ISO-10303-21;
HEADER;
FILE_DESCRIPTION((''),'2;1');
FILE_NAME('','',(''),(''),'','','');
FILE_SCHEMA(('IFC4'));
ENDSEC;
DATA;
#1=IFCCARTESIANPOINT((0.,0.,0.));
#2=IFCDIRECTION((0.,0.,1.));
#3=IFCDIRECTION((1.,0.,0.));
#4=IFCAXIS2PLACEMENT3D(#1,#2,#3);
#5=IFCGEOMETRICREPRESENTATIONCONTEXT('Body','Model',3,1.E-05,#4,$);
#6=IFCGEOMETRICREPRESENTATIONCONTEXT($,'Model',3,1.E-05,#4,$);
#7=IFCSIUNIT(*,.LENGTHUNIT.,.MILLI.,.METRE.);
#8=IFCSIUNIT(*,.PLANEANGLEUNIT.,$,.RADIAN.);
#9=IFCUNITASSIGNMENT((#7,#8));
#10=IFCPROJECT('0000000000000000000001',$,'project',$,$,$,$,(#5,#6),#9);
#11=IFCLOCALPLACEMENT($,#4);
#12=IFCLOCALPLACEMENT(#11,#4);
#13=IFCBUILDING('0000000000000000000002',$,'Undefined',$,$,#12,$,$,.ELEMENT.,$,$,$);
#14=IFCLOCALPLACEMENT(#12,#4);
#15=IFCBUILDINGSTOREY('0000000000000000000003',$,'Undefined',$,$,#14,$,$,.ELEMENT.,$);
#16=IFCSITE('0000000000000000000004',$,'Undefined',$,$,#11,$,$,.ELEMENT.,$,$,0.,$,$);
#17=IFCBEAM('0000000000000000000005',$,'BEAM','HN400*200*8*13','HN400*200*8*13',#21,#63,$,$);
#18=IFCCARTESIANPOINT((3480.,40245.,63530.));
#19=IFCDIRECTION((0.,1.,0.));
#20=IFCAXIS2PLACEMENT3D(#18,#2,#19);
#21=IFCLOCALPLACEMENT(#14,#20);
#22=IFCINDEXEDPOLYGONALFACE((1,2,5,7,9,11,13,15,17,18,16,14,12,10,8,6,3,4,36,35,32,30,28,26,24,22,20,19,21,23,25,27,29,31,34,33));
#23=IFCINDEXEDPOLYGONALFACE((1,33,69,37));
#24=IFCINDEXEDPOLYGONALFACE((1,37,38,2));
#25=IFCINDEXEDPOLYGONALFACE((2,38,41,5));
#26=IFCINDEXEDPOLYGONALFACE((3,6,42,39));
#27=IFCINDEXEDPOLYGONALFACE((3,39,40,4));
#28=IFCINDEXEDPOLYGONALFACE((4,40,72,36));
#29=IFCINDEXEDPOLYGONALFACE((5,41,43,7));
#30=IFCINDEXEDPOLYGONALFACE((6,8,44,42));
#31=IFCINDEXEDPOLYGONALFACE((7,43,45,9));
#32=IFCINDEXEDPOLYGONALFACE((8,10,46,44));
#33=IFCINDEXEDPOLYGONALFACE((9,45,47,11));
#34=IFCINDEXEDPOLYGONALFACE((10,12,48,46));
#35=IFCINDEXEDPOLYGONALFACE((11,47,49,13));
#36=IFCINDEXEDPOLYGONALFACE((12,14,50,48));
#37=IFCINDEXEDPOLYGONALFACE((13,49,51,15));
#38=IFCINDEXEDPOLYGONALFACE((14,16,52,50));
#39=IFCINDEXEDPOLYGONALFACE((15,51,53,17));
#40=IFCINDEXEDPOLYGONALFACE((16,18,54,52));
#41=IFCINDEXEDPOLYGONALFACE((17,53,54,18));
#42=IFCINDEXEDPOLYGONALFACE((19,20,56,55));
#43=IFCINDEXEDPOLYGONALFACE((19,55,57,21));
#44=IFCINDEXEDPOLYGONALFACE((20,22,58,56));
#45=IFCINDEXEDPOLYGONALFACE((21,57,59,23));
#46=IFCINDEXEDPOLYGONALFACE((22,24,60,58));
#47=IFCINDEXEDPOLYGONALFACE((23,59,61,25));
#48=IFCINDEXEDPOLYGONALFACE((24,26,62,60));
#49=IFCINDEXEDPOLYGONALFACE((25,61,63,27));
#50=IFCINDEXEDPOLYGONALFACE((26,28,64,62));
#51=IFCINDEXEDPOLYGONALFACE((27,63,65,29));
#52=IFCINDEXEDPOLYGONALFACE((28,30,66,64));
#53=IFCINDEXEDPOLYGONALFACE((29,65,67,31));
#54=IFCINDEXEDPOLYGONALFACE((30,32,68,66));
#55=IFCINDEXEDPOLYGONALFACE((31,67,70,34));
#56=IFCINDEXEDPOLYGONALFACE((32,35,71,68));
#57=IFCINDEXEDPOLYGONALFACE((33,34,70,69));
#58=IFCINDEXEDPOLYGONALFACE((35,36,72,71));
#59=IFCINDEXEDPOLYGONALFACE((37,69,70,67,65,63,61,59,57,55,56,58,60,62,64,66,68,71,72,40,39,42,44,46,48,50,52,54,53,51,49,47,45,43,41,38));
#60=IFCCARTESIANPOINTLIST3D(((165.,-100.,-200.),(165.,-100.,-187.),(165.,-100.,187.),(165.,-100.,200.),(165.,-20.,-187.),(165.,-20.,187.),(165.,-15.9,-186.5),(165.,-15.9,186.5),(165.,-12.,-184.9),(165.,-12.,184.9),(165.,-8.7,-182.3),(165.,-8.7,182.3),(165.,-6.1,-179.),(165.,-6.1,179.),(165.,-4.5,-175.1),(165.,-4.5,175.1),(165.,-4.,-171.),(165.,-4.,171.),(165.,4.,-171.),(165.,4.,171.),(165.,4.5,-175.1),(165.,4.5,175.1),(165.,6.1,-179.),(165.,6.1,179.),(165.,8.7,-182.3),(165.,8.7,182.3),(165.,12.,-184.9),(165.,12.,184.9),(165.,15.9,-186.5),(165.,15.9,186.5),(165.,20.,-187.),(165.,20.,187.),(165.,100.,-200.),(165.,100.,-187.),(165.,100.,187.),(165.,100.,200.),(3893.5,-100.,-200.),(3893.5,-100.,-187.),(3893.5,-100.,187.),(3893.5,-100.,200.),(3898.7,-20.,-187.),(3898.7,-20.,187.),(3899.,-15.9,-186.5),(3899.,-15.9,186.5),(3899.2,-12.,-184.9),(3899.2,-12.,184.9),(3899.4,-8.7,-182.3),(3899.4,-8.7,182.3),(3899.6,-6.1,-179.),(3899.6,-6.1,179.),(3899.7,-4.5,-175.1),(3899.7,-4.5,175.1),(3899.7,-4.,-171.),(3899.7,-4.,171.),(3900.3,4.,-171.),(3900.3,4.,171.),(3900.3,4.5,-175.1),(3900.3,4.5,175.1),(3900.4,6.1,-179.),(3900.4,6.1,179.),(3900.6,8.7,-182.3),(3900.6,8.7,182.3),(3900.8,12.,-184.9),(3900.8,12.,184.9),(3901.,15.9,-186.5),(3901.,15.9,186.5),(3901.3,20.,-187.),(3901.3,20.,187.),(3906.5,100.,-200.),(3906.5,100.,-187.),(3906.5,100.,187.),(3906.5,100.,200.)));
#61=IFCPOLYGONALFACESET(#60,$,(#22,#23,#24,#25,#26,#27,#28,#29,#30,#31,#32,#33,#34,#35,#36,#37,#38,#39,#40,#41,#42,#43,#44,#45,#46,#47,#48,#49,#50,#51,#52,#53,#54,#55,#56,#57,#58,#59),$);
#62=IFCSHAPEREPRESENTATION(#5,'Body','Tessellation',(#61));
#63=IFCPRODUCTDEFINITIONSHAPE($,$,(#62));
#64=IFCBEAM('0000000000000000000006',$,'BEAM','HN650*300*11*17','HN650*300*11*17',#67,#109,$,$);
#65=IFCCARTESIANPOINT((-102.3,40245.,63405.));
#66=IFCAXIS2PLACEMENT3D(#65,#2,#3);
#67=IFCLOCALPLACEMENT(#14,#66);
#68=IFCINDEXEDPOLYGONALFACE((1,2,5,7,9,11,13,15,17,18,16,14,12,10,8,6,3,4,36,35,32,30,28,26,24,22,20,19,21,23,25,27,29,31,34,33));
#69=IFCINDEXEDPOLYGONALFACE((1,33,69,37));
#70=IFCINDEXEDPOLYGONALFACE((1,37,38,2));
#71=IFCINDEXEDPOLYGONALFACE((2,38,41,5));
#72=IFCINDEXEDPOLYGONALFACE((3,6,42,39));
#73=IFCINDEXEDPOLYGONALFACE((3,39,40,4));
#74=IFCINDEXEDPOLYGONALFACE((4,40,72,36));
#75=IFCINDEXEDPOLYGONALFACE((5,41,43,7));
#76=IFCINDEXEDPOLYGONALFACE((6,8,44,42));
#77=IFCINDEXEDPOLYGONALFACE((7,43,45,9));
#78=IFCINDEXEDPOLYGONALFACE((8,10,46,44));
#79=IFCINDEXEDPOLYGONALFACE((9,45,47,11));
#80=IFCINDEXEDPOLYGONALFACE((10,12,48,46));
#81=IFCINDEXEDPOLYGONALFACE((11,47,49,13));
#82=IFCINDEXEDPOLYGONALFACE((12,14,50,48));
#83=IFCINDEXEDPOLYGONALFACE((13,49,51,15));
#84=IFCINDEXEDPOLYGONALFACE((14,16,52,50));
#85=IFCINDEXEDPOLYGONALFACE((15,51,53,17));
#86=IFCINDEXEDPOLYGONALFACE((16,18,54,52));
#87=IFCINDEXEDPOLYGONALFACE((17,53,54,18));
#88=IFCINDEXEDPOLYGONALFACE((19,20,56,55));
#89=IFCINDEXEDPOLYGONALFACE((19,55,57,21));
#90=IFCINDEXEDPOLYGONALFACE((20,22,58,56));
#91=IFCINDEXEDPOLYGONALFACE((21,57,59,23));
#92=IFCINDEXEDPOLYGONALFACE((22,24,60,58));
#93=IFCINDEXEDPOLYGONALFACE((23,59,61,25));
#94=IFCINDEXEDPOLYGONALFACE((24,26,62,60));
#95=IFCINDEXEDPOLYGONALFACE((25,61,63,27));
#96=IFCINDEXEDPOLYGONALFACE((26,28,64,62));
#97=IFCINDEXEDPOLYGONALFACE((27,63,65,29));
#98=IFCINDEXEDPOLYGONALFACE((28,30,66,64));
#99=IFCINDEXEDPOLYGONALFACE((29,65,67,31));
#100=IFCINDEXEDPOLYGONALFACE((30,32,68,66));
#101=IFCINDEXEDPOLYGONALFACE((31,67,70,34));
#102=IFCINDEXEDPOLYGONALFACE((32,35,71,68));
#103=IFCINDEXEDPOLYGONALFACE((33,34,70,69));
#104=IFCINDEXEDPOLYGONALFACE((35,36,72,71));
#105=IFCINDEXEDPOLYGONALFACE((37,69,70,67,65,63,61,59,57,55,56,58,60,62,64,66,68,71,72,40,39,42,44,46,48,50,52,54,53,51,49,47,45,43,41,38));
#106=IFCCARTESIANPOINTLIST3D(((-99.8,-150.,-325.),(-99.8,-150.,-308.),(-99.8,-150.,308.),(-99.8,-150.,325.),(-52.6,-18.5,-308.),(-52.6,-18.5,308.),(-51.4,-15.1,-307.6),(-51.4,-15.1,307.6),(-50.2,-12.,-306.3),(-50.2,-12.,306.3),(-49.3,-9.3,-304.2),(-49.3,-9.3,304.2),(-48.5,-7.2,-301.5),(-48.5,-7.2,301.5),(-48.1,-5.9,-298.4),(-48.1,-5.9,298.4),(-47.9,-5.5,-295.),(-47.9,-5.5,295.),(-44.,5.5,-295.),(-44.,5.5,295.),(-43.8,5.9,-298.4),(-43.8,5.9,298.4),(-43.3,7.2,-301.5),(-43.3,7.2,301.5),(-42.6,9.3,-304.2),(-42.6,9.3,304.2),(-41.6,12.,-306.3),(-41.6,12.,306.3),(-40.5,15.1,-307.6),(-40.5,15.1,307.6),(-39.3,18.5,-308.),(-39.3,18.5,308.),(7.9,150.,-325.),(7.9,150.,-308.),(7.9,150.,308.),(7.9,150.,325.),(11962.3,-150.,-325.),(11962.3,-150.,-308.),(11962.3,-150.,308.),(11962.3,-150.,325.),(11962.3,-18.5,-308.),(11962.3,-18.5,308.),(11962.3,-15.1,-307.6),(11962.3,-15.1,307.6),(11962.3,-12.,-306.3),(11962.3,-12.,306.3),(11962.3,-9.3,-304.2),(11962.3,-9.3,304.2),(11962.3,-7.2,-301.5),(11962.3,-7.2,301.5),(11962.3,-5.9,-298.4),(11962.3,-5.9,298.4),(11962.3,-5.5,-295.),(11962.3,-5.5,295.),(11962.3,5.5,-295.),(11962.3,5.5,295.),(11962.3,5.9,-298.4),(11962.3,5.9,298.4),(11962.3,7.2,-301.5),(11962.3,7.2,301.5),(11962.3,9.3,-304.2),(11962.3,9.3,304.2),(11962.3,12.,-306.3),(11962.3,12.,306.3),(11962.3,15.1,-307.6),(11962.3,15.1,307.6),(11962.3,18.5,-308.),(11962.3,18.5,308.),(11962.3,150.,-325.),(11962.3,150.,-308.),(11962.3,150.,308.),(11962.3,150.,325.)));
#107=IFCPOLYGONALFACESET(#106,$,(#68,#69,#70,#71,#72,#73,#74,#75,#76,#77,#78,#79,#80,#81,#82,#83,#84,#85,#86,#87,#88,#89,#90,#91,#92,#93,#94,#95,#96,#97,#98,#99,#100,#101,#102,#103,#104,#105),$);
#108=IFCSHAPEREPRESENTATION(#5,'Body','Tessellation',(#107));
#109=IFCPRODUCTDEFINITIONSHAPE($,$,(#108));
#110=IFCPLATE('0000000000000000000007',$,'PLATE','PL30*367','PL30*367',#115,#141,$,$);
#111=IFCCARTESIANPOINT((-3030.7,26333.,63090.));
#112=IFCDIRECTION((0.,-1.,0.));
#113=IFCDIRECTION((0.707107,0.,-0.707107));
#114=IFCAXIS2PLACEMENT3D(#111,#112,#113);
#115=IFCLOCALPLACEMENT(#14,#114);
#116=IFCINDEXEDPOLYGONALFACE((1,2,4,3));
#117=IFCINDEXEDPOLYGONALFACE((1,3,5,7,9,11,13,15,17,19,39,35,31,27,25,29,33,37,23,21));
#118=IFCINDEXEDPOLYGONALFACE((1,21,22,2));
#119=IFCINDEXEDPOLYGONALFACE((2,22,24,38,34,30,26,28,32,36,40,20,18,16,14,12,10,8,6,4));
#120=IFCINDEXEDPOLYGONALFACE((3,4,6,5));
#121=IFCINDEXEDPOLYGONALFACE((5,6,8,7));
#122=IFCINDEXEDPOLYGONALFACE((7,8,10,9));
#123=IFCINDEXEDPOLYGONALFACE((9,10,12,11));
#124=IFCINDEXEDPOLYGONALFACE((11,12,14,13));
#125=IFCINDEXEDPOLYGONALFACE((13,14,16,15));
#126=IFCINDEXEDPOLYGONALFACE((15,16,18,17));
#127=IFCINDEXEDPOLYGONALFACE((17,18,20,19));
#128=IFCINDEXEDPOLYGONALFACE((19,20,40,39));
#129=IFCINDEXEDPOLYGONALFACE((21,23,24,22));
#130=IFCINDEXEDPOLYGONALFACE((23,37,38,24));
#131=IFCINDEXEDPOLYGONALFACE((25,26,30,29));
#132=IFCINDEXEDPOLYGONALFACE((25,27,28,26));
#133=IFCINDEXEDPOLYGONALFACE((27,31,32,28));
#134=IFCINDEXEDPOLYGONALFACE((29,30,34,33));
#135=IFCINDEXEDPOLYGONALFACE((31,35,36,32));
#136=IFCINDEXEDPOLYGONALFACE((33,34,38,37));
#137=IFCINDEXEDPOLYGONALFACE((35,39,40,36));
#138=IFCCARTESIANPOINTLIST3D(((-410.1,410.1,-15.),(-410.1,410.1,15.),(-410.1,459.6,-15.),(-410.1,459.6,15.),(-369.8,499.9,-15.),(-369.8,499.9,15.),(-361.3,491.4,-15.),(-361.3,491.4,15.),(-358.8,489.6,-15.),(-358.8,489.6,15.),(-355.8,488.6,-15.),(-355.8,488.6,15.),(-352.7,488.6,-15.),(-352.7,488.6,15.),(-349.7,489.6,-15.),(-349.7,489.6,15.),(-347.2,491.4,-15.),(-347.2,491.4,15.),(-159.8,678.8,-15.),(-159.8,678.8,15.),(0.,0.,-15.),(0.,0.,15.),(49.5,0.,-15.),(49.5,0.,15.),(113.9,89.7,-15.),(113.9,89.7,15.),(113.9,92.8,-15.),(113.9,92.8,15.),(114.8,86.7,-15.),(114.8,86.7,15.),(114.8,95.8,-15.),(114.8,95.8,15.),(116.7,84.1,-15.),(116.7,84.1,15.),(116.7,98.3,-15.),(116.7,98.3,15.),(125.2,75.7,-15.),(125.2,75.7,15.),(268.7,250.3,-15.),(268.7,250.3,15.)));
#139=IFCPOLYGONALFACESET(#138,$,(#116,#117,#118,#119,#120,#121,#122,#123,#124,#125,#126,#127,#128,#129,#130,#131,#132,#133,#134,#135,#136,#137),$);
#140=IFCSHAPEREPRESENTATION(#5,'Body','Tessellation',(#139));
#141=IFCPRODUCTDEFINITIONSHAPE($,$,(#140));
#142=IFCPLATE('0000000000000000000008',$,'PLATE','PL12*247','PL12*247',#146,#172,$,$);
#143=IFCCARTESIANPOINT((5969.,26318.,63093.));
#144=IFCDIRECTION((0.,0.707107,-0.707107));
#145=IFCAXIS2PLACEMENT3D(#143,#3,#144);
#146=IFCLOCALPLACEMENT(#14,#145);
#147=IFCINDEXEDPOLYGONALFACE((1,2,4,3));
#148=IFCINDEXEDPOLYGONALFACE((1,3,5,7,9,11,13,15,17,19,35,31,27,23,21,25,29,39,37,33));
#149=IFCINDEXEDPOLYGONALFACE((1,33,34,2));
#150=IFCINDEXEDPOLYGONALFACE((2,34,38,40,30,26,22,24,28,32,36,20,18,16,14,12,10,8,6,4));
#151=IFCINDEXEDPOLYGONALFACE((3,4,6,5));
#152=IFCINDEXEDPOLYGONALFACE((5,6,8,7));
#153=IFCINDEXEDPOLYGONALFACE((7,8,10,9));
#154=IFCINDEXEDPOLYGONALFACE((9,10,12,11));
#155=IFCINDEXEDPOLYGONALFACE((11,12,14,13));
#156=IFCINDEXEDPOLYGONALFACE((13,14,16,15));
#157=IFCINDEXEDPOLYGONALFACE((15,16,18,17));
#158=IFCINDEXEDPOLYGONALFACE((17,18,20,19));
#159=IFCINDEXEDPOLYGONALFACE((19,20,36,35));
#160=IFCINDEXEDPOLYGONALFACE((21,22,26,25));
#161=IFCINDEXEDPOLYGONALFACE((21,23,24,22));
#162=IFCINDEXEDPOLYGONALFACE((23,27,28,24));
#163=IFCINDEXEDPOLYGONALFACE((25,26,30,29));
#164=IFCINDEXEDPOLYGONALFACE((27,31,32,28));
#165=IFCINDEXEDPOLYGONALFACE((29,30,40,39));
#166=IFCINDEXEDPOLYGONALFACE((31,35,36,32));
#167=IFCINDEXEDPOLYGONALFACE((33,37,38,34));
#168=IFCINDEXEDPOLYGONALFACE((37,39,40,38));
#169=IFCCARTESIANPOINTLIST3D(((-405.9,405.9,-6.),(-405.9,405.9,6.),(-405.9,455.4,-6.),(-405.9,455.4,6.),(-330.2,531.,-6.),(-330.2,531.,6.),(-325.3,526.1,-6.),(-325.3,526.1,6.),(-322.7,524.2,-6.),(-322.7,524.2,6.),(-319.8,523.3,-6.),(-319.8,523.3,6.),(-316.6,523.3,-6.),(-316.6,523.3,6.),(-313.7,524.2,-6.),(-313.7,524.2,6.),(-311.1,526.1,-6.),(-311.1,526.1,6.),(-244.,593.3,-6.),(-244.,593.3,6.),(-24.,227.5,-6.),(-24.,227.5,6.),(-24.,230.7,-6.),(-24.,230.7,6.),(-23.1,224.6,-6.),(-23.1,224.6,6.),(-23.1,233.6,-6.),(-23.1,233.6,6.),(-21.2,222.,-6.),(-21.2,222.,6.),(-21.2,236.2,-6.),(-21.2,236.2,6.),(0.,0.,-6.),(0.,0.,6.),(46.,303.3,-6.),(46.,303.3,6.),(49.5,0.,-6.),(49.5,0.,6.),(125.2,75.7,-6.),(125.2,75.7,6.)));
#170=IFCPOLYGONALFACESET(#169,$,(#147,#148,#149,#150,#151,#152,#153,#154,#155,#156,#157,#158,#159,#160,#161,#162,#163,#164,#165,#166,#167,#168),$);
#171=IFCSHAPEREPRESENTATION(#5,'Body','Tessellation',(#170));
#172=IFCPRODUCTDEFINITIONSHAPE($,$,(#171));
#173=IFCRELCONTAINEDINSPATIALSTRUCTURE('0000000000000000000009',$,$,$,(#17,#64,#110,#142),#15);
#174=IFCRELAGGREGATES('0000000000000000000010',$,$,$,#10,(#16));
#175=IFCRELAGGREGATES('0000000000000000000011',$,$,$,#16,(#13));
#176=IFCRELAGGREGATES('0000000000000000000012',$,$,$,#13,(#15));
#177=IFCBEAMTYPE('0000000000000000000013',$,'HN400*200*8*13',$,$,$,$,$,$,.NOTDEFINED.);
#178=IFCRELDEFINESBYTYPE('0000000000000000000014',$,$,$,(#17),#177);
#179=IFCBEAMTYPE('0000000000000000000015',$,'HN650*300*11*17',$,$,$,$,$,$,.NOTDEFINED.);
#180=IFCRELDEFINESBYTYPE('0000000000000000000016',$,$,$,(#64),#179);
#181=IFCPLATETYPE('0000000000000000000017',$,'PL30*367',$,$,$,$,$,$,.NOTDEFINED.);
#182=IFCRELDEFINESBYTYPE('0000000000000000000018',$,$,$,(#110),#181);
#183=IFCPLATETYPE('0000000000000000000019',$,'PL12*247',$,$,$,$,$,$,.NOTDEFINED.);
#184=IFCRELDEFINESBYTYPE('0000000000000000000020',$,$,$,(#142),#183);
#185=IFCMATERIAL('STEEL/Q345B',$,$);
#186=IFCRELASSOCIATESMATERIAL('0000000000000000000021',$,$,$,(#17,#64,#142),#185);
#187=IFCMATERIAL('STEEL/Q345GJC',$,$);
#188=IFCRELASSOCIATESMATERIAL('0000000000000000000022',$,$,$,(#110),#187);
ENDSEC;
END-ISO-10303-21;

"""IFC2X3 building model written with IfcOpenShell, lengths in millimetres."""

from ifc_helpers import new_model, si_unit, frame, origin_with_axes, origin_2d_with_axis, place, context, project, spatial, polyline, i_section, outline, extrude, clip, halfspace, material, type_object, element, save


model = new_model("IFC2X3")

# Units and contexts
model_context_1 = context("Model", 3, precision=1e-05, world=origin_with_axes(), identifier="Body")
model_context_2 = context("Model", 3, precision=1e-05, world=origin_with_axes())
ifc_project = project(units=[si_unit("LENGTHUNIT", "METRE", prefix="MILLI"), si_unit("PLANEANGLEUNIT", "RADIAN")], contexts=[model_context_1, model_context_2])

# Site, building, storey
site_placement = place(None, origin_with_axes())
site = spatial("IfcSite", under=ifc_project, at=site_placement, Name="Undefined", CompositionType="ELEMENT", RefElevation=0.0)
building_placement = place(site_placement, origin_with_axes())
building = spatial("IfcBuilding", under=site, at=building_placement, Name="Undefined", CompositionType="ELEMENT")
storey_placement = place(building_placement, origin_with_axes())
storey = spatial("IfcBuildingStorey", under=building, at=storey_placement, Name="Undefined", CompositionType="ELEMENT")

# Shared definitions
ifc_material_1 = material(Name="STEEL/Q345B")

# Beams
beam_type_1 = type_object("IfcBeamType", Name="HN400*200*8*13", PredefinedType="NOTDEFINED")
beam_1_placement = place(storey_placement, frame((3480.0, 40245.0, 63530.0), z_axis=(0.0, 0.0, 1.0), x_axis=(0.0, 1.0, 0.0)))
element("IfcBeam", 1, at=beam_1_placement, inside=storey, type_object=beam_type_1, material=ifc_material_1, Name="BEAM", Description="HN400*200*8*13", ObjectType="HN400*200*8*13", context=model_context_1, shape_type="Clipping", body=[
    clip(clip(extrude(i_section(OverallWidth=200.0, OverallDepth=400.0, WebThickness=8.0, FlangeThickness=13.0, FilletRadius=16.0, at=origin_2d_with_axis()), frame((3906.6, 0.0, 0.0), z_axis=(-1.0, 0.0, 0.0), x_axis=(0.0, -1.0, 0.0)), (0.0, 0.0, 1.0), 3741.6), halfspace(frame((3900.9, 13.2, 300.0), z_axis=(0.997873, -0.065183, 0.0), x_axis=(0.065184, 0.997873, 0.0)), False)), halfspace(frame((165.0, 0.0, 300.0), z_axis=(-1.0, 0.0, 0.0), x_axis=(0.0, -1.0, 0.0)), False)),
])
beam_type_2 = type_object("IfcBeamType", Name="HN650*300*11*17", PredefinedType="NOTDEFINED")
beam_2_placement = place(storey_placement, frame((-102.3, 40245.0, 63405.0), z_axis=(0.0, 0.0, 1.0), x_axis=(1.0, 0.0, 0.0)))
element("IfcBeam", 2, at=beam_2_placement, inside=storey, type_object=beam_type_2, material=ifc_material_1, Name="BEAM", Description="HN650*300*11*17", ObjectType="HN650*300*11*17", context=model_context_1, shape_type="Clipping", body=[
    clip(clip(clip(extrude(i_section(OverallWidth=300.0, OverallDepth=650.0, WebThickness=11.0, FlangeThickness=17.0, FilletRadius=13.0, at=origin_2d_with_axis()), frame((11962.3, 0.0, 0.0), z_axis=(-1.0, 0.0, 0.0), x_axis=(0.0, -1.0, 0.0)), (0.0, 0.0, 1.0), 12062.6), halfspace(frame((11962.3, -157.8, 375.0), z_axis=(1.0, 0.0, 0.0), x_axis=(0.0, 0.0, 1.0)), False)), halfspace(frame((-47.7, -5.1, 425.0), z_axis=(-0.941212, 0.337816, 0.0), x_axis=(-0.337816, -0.941212, 0.0)), False)), halfspace(frame((-65.0, -53.0, 425.0), z_axis=(-0.941212, 0.337816, 0.0), x_axis=(-0.337816, -0.941212, 0.0)), False)),
])
ifc_material_2 = material(Name="STEEL/Q345GJC")

# Plates
plate_type_1 = type_object("IfcPlateType", Name="PL30*367", PredefinedType="NOTDEFINED")
plate_1_placement = place(storey_placement, frame((-3030.7, 26333.0, 63090.0), z_axis=(0.0, -1.0, 0.0), x_axis=(0.707107, 0.0, -0.707107)))
element("IfcPlate", 3, at=plate_1_placement, inside=storey, type_object=plate_type_1, material=ifc_material_2, Name="PLATE", Description="PL30*367", ObjectType="PL30*367", context=model_context_1, shape_type="SweptSolid", body=[
    extrude(outline(polyline([(0.0, 0.0), (49.5, 0.0), (125.2, 75.7), (116.7, 84.1), (114.8, 86.7), (113.9, 89.7), (113.9, 92.8), (114.8, 95.8), (116.7, 98.3), (268.7, 250.3), (-159.8, 678.8), (-347.2, 491.4), (-349.7, 489.6), (-352.7, 488.6), (-355.8, 488.6), (-358.8, 489.6), (-361.3, 491.4), (-369.8, 499.9), (-410.1, 459.6), (-410.1, 410.1), (0.0, 0.0)])), frame((0.0, 0.0, -15.0), z_axis=(0.0, 0.0, 1.0), x_axis=(1.0, 0.0, 0.0)), (0.0, 0.0, 1.0), 30.0),
])
plate_type_2 = type_object("IfcPlateType", Name="PL12*247", PredefinedType="NOTDEFINED")
for number, where, z_axis, x_axis, name in (
    (4, (5969.0, 26318.0, 63093.0), (1.0, 0.0, 0.0), (0.0, 0.707107, -0.707107), "PLATE"),
):
    element("IfcPlate", number, at=place(storey_placement, frame(where, z_axis=z_axis, x_axis=x_axis)), inside=storey, type_object=plate_type_2, material=ifc_material_1, Name=name, Description="PL12*247", ObjectType="PL12*247", context=model_context_1, shape_type="SweptSolid", body=[
        extrude(outline(polyline([(0.0, 0.0), (49.5, 0.0), (125.2, 75.7), (-21.2, 222.0), (-23.1, 224.6), (-24.0, 227.5), (-24.0, 230.7), (-23.1, 233.6), (-21.2, 236.2), (46.0, 303.3), (-244.0, 593.3), (-311.1, 526.1), (-313.7, 524.2), (-316.6, 523.3), (-319.8, 523.3), (-322.7, 524.2), (-325.3, 526.1), (-330.2, 531.0), (-405.9, 455.4), (-405.9, 405.9), (0.0, 0.0)])), frame((0.0, 0.0, -6.0), z_axis=(0.0, 0.0, 1.0), x_axis=(1.0, 0.0, 0.0)), (0.0, 0.0, 1.0), 12.0),
    ])

save(model, "model.ifc")
